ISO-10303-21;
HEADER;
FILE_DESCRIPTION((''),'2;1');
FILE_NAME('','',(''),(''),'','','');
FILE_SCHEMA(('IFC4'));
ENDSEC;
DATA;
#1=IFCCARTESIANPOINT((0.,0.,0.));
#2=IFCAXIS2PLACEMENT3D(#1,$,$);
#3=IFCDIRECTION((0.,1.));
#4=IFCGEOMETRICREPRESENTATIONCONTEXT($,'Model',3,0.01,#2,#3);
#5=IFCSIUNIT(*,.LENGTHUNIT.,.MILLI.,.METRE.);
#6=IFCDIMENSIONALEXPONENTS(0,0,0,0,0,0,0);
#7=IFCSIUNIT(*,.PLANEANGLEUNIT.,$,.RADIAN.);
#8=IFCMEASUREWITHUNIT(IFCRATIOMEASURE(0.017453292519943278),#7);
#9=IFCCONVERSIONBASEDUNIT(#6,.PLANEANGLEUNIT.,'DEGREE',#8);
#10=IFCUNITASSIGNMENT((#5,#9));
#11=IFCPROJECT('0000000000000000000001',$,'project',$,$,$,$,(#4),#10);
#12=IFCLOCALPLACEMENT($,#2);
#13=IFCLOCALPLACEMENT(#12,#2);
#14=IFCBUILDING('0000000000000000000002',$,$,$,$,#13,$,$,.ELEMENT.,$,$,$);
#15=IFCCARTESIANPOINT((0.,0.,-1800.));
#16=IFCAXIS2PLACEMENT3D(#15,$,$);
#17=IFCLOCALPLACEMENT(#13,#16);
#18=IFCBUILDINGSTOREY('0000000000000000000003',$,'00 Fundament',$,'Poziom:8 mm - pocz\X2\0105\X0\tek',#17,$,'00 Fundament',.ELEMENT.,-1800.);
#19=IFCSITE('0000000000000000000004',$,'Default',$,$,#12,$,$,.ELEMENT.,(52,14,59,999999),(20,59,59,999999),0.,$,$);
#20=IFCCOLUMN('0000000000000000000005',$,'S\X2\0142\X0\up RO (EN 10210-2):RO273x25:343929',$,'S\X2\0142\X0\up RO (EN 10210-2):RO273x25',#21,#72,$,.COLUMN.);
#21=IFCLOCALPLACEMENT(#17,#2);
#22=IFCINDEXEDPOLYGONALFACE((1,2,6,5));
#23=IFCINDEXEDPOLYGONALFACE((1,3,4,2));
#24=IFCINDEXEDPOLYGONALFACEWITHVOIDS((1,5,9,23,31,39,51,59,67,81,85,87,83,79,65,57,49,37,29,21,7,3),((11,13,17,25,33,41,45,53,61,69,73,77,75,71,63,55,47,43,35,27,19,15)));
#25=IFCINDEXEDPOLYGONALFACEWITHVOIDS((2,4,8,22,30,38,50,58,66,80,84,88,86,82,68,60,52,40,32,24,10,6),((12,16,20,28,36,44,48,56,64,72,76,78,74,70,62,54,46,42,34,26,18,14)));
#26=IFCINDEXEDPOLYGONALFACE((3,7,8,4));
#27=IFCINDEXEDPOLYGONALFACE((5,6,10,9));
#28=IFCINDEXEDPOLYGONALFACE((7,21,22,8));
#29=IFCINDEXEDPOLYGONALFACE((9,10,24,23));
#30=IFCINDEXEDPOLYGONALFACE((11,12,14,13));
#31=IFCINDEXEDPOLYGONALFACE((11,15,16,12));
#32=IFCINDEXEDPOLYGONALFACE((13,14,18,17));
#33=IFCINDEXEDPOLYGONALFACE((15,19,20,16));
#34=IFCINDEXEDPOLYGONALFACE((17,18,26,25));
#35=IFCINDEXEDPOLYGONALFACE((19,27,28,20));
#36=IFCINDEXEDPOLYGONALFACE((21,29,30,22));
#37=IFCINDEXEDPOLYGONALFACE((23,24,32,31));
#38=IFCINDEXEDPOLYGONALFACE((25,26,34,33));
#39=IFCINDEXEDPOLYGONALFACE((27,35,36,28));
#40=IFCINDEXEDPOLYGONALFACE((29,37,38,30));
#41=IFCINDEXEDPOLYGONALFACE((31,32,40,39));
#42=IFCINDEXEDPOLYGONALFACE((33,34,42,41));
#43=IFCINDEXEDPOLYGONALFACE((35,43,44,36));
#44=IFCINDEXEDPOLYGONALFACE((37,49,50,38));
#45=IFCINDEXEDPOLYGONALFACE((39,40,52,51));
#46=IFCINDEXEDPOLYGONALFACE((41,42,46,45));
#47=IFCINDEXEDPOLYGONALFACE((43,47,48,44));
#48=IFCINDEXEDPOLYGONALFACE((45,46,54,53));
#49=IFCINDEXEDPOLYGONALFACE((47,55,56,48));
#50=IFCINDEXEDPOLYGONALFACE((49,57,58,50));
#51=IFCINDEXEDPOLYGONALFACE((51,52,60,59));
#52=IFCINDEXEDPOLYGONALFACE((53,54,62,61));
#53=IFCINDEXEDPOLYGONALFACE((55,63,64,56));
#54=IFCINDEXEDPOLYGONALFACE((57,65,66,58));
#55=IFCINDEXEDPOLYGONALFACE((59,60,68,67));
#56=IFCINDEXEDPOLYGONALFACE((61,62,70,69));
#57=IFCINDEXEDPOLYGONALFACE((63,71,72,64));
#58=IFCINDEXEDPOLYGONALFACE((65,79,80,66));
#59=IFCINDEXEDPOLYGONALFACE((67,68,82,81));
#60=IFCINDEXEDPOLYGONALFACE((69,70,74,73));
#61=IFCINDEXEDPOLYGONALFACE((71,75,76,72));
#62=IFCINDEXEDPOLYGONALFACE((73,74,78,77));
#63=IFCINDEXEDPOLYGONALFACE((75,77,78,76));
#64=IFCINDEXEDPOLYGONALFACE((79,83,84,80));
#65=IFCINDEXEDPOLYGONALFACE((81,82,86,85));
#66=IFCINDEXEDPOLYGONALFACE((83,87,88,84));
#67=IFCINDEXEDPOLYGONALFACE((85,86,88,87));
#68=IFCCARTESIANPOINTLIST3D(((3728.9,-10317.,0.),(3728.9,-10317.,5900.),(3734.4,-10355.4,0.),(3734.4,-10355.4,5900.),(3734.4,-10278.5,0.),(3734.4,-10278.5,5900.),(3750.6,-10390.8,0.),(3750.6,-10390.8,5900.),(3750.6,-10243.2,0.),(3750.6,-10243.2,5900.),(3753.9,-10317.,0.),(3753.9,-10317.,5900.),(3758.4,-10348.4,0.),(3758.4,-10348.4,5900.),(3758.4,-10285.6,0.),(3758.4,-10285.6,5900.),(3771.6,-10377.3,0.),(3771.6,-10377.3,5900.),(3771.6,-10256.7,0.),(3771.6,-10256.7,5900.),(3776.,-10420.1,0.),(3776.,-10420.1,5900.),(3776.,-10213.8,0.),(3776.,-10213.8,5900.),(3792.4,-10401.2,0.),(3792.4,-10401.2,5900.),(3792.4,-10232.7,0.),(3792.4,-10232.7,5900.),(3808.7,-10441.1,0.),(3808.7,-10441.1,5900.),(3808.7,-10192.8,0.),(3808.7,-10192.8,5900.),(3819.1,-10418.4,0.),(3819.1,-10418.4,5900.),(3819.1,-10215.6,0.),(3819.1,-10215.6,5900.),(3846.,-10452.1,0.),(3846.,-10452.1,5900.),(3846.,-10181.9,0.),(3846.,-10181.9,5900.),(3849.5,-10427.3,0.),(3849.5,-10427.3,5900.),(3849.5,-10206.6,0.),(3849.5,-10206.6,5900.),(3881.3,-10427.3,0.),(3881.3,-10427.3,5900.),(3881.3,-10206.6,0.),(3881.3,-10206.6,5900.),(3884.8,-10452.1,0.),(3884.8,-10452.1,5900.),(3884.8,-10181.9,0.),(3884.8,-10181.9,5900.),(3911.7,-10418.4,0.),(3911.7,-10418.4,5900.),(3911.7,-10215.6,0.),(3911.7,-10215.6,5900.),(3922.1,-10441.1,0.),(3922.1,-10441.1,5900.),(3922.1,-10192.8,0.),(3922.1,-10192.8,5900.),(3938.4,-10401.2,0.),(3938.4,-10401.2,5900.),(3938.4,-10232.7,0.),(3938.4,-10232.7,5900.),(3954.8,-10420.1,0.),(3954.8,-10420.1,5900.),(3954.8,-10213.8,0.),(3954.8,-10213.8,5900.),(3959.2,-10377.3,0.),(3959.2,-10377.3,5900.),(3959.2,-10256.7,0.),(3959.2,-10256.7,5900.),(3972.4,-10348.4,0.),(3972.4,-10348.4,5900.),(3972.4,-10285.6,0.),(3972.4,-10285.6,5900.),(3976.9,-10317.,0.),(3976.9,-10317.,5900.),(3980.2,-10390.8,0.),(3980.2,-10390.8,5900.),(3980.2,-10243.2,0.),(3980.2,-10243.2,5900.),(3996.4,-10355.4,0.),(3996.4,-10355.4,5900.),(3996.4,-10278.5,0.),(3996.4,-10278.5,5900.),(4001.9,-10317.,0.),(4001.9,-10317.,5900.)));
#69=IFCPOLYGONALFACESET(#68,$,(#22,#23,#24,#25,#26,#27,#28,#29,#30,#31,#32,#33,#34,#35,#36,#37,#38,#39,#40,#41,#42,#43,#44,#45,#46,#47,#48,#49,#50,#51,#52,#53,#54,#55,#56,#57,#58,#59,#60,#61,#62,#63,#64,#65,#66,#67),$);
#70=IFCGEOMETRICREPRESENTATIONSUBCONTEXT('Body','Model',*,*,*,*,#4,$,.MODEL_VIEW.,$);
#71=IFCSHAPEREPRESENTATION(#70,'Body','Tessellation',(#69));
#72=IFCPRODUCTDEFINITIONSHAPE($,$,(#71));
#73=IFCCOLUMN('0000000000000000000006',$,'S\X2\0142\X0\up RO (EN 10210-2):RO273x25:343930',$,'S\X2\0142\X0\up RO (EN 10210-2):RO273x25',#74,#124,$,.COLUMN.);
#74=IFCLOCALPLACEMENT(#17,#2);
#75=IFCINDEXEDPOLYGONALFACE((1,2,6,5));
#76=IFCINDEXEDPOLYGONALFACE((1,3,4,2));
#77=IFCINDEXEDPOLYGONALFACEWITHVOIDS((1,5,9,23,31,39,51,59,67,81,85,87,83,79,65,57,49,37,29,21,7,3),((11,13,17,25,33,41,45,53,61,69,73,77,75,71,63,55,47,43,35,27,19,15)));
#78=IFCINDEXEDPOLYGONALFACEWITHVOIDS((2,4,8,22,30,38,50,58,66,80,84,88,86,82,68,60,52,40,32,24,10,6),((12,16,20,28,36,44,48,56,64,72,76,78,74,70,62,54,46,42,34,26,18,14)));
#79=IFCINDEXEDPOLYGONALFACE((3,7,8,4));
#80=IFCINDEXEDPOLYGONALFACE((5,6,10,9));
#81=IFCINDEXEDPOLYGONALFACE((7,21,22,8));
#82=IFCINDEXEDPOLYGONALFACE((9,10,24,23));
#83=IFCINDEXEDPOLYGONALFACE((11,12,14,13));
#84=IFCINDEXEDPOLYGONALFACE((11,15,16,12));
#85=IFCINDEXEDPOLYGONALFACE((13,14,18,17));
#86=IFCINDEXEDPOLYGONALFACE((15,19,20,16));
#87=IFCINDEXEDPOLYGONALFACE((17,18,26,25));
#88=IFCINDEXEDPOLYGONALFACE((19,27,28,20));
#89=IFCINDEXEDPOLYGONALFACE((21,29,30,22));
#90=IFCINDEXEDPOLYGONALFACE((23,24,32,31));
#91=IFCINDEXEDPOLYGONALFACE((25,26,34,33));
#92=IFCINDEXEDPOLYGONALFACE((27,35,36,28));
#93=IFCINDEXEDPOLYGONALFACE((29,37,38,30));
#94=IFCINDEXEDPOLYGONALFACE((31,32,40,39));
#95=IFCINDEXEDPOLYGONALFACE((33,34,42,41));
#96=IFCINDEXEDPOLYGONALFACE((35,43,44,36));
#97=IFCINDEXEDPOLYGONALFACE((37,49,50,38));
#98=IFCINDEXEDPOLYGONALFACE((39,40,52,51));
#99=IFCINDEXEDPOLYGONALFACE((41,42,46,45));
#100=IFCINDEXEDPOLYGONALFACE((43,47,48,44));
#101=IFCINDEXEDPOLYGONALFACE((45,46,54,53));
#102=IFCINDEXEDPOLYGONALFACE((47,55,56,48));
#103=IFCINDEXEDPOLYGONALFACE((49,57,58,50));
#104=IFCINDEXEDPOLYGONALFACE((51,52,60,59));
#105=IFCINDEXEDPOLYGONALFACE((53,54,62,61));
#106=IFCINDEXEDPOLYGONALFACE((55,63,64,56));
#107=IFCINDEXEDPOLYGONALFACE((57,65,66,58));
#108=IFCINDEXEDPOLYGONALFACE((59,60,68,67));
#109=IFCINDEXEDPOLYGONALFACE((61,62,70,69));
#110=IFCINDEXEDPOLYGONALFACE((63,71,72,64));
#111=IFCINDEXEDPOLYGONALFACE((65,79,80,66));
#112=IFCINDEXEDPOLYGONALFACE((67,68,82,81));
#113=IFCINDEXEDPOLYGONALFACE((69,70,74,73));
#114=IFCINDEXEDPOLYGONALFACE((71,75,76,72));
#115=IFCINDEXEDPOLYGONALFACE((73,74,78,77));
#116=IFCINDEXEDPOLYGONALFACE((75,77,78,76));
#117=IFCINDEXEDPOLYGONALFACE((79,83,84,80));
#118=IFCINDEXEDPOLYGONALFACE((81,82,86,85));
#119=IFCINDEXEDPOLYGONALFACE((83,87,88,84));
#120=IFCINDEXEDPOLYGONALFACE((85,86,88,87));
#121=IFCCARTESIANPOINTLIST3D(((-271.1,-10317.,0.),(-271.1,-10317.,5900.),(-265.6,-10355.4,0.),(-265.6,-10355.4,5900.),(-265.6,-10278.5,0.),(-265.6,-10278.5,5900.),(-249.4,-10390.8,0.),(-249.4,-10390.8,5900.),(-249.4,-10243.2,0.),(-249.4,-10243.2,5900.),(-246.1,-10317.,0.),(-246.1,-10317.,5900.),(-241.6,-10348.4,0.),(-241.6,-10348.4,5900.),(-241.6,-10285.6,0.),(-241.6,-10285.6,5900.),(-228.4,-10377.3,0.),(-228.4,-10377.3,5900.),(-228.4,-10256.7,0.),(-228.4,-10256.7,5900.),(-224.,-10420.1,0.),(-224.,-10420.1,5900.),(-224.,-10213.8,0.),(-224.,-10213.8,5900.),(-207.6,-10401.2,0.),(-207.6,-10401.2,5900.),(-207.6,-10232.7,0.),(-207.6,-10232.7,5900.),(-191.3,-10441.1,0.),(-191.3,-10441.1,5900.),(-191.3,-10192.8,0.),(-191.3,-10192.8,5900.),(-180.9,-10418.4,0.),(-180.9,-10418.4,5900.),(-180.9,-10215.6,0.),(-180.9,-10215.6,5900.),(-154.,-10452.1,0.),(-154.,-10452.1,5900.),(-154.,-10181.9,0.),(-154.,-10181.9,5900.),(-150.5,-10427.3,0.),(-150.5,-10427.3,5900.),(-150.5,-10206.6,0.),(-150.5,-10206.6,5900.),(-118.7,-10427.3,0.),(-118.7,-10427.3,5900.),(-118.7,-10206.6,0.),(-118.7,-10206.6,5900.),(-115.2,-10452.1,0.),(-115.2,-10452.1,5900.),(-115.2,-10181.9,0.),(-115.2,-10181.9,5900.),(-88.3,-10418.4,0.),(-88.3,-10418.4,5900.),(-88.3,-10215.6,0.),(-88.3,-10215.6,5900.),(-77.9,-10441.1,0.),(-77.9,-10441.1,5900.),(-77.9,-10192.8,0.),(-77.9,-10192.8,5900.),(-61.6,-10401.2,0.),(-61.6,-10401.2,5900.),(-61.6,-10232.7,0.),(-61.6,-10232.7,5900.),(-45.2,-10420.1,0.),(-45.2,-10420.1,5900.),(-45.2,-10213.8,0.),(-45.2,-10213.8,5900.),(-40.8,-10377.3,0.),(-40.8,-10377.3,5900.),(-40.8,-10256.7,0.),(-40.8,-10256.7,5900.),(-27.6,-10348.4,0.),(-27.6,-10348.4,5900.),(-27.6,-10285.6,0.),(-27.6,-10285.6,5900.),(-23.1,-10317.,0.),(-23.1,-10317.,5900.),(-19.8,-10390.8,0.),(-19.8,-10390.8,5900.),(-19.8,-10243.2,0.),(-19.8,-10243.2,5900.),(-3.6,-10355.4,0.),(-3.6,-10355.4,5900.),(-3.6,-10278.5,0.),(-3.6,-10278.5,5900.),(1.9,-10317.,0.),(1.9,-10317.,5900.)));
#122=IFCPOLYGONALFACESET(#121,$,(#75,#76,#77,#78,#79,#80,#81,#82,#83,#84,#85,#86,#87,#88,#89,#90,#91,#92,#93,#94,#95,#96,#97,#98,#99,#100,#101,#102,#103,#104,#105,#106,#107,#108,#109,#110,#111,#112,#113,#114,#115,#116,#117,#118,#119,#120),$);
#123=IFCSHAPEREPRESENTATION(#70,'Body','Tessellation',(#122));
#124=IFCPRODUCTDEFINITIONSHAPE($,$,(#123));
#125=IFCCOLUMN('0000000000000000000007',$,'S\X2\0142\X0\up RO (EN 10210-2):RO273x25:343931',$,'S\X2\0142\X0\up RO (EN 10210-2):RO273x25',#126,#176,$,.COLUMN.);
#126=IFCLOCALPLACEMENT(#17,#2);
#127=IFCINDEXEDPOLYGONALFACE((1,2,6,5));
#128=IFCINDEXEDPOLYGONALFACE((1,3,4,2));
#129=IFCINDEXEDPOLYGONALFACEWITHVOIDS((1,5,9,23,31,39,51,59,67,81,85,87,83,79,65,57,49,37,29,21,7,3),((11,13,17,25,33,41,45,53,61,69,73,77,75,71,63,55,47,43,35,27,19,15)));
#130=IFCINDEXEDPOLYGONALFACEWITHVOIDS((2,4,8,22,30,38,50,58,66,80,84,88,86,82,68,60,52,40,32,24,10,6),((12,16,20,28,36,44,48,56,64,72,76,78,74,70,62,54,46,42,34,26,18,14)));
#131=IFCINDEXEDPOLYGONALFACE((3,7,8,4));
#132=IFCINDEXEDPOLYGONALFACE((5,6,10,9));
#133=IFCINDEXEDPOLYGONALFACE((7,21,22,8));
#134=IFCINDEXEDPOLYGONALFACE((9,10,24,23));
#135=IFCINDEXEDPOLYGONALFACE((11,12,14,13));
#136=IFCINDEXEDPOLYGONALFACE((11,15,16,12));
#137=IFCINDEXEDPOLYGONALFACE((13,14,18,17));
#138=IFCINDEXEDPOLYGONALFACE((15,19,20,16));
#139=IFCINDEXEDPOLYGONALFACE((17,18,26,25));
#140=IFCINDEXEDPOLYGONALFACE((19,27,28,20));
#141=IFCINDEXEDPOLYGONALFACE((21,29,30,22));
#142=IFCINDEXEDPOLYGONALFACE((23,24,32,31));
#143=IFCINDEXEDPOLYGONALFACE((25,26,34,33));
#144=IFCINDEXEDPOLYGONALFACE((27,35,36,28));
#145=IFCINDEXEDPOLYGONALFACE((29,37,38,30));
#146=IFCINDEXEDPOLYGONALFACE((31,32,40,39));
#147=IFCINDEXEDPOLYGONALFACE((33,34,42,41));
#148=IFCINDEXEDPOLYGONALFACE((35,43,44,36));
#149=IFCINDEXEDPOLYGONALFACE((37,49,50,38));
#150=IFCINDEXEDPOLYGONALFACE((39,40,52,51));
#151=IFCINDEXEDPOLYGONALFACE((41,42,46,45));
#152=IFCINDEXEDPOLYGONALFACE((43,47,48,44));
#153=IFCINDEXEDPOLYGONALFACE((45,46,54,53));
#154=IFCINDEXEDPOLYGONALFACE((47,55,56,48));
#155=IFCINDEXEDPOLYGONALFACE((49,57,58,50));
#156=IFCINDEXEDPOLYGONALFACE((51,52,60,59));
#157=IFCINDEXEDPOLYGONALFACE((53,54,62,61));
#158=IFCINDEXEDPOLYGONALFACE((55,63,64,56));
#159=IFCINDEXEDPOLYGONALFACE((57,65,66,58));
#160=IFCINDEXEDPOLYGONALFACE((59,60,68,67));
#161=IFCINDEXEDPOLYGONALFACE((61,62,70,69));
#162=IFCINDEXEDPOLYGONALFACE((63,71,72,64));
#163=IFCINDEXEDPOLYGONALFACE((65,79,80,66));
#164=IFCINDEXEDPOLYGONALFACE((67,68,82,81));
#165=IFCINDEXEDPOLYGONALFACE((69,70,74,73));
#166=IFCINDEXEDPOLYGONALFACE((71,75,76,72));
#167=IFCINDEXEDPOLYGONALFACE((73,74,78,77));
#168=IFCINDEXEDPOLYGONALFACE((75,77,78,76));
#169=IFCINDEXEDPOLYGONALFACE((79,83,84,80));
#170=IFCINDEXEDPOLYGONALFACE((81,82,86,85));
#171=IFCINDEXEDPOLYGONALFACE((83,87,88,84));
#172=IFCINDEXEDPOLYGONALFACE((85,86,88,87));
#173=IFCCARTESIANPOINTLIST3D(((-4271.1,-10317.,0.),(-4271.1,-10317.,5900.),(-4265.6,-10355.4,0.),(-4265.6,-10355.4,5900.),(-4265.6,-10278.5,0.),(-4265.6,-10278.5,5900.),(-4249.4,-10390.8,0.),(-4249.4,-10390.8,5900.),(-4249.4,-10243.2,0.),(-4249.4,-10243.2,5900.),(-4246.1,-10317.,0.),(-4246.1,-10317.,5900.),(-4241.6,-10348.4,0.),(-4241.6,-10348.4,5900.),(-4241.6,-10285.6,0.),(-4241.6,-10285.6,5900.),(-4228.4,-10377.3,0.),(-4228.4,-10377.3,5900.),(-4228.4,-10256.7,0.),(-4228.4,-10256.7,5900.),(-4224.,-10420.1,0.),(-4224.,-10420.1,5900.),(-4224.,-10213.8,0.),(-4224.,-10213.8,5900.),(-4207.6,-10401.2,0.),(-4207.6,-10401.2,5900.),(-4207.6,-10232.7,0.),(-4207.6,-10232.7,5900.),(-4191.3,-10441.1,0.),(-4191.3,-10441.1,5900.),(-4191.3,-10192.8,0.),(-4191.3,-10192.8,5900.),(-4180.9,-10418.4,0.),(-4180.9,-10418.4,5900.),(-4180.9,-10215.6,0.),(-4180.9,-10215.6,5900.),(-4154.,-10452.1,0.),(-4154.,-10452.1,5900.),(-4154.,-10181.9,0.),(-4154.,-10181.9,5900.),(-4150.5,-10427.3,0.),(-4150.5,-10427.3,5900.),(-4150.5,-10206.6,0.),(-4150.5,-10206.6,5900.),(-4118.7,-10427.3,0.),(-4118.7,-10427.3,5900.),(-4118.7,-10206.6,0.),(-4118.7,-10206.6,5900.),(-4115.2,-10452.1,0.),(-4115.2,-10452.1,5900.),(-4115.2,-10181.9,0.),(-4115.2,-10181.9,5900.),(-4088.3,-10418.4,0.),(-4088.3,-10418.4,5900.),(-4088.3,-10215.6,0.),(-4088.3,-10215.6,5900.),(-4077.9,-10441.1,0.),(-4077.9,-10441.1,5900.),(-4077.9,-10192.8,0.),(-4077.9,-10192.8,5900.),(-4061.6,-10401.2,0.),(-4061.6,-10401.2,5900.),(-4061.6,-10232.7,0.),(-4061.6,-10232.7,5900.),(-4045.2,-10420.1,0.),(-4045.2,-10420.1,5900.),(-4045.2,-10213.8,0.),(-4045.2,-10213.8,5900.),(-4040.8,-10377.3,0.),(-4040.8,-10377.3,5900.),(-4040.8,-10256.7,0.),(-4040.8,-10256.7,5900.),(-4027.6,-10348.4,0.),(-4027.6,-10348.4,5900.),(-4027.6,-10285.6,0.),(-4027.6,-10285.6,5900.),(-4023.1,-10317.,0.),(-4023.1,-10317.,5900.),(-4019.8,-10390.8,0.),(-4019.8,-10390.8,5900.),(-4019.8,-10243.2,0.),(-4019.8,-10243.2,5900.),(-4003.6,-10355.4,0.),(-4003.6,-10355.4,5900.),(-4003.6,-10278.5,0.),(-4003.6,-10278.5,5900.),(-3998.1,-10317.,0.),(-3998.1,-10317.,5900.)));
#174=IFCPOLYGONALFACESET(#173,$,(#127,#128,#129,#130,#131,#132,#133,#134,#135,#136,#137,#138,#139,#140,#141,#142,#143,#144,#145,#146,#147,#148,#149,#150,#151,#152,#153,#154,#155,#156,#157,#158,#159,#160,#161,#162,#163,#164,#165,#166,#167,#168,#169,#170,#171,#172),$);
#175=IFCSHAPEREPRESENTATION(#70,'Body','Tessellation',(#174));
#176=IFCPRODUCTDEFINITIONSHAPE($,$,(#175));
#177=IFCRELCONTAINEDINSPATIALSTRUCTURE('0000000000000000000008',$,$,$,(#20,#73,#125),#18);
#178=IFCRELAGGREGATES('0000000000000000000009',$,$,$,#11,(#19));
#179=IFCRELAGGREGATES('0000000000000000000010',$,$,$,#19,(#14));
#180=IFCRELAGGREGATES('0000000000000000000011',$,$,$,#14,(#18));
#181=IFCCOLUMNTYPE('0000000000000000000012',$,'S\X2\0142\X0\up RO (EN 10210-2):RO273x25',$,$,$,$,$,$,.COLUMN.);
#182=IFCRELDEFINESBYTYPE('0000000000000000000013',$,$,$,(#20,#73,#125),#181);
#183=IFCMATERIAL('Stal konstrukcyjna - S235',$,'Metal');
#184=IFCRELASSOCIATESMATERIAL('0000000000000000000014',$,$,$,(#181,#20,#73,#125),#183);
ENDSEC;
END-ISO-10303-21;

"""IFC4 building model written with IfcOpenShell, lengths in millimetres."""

from ifc_helpers import new_model, entity, si_unit, converted_unit, direction, frame, origin, place, context, subcontext, project, spatial, arc, indexed_curve, outline, extrude, source, transform, mapped, material, type_object, type_shapes, element, save


model = new_model("IFC4")

# Units and contexts
model_context = context("Model", 3, precision=0.01, world=origin(), true_north=direction((0.0, 1.0)))
body_context = subcontext(model_context, "Body", "Model", "MODEL_VIEW")
ifc_project = project(units=[si_unit("LENGTHUNIT", "METRE", prefix="MILLI"), converted_unit("PLANEANGLEUNIT", "DEGREE", entity("IfcRatioMeasure", 0.017453292519943278), si_unit("PLANEANGLEUNIT", "RADIAN"), dimensions=[0, 0, 0, 0, 0, 0, 0])], contexts=[model_context])

# Site, building, storey
site_placement = place(None, origin())
site = spatial("IfcSite", under=ifc_project, at=site_placement, Name="Default", CompositionType="ELEMENT", RefLatitude=(52, 14, 59, 999999), RefLongitude=(20, 59, 59, 999999), RefElevation=0.0)
building_placement = place(site_placement, origin())
building = spatial("IfcBuilding", under=site, at=building_placement, CompositionType="ELEMENT")
storey_placement = place(building_placement, frame((0.0, 0.0, -1800.0)))
storey = spatial("IfcBuildingStorey", under=building, at=storey_placement, Name="00 Fundament", ObjectType="Poziom:8 mm - początek", LongName="00 Fundament", CompositionType="ELEMENT", Elevation=-1800.0)

# Columns
ifc_material_1 = material(Name="Stal konstrukcyjna - S235", Category="Metal")
column_type = type_object("IfcColumnType", Name="Słup RO (EN 10210-2):RO273x25", PredefinedType="COLUMN", material=ifc_material_1)
shared_shape = source(origin(), body_context, "Body", "SweptSolid", [
    extrude(outline(indexed_curve([(-136.5, 0.0), (0.0, -136.5), (136.5, 0.0), (0.0, 136.5)], segments=[arc(1, 2, 3), arc(3, 4, 1)], self_intersect=False), holes=[indexed_curve([(-111.5, 0.0), (0.0, 111.5), (111.5, 0.0), (0.0, -111.5)], segments=[arc(1, 2, 3), arc(3, 4, 1)], self_intersect=False)]), frame((0.0, 0.0, -1800.0)), (0.0, 0.0, 1.0), 5900.0),
])
type_shapes(column_type, [shared_shape])
for number, where, name in (
    (1, (3865.4, -10317.0, 1800.0), "Słup RO (EN 10210-2):RO273x25:343929"),
    (2, (-134.6, -10317.0, 1800.0), "Słup RO (EN 10210-2):RO273x25:343930"),
    (3, (-4134.6, -10317.0, 1800.0), "Słup RO (EN 10210-2):RO273x25:343931"),
):
    element("IfcColumn", number, at=place(storey_placement, frame(where)), inside=storey, type_object=column_type, material=ifc_material_1, Name=name, ObjectType="Słup RO (EN 10210-2):RO273x25", PredefinedType="COLUMN", context=body_context, shape_type="MappedRepresentation", body=[
        mapped(shared_shape, transform((0.0, 0.0, 0.0), scale=1.0)),
    ])

save(model, "model.ifc")
